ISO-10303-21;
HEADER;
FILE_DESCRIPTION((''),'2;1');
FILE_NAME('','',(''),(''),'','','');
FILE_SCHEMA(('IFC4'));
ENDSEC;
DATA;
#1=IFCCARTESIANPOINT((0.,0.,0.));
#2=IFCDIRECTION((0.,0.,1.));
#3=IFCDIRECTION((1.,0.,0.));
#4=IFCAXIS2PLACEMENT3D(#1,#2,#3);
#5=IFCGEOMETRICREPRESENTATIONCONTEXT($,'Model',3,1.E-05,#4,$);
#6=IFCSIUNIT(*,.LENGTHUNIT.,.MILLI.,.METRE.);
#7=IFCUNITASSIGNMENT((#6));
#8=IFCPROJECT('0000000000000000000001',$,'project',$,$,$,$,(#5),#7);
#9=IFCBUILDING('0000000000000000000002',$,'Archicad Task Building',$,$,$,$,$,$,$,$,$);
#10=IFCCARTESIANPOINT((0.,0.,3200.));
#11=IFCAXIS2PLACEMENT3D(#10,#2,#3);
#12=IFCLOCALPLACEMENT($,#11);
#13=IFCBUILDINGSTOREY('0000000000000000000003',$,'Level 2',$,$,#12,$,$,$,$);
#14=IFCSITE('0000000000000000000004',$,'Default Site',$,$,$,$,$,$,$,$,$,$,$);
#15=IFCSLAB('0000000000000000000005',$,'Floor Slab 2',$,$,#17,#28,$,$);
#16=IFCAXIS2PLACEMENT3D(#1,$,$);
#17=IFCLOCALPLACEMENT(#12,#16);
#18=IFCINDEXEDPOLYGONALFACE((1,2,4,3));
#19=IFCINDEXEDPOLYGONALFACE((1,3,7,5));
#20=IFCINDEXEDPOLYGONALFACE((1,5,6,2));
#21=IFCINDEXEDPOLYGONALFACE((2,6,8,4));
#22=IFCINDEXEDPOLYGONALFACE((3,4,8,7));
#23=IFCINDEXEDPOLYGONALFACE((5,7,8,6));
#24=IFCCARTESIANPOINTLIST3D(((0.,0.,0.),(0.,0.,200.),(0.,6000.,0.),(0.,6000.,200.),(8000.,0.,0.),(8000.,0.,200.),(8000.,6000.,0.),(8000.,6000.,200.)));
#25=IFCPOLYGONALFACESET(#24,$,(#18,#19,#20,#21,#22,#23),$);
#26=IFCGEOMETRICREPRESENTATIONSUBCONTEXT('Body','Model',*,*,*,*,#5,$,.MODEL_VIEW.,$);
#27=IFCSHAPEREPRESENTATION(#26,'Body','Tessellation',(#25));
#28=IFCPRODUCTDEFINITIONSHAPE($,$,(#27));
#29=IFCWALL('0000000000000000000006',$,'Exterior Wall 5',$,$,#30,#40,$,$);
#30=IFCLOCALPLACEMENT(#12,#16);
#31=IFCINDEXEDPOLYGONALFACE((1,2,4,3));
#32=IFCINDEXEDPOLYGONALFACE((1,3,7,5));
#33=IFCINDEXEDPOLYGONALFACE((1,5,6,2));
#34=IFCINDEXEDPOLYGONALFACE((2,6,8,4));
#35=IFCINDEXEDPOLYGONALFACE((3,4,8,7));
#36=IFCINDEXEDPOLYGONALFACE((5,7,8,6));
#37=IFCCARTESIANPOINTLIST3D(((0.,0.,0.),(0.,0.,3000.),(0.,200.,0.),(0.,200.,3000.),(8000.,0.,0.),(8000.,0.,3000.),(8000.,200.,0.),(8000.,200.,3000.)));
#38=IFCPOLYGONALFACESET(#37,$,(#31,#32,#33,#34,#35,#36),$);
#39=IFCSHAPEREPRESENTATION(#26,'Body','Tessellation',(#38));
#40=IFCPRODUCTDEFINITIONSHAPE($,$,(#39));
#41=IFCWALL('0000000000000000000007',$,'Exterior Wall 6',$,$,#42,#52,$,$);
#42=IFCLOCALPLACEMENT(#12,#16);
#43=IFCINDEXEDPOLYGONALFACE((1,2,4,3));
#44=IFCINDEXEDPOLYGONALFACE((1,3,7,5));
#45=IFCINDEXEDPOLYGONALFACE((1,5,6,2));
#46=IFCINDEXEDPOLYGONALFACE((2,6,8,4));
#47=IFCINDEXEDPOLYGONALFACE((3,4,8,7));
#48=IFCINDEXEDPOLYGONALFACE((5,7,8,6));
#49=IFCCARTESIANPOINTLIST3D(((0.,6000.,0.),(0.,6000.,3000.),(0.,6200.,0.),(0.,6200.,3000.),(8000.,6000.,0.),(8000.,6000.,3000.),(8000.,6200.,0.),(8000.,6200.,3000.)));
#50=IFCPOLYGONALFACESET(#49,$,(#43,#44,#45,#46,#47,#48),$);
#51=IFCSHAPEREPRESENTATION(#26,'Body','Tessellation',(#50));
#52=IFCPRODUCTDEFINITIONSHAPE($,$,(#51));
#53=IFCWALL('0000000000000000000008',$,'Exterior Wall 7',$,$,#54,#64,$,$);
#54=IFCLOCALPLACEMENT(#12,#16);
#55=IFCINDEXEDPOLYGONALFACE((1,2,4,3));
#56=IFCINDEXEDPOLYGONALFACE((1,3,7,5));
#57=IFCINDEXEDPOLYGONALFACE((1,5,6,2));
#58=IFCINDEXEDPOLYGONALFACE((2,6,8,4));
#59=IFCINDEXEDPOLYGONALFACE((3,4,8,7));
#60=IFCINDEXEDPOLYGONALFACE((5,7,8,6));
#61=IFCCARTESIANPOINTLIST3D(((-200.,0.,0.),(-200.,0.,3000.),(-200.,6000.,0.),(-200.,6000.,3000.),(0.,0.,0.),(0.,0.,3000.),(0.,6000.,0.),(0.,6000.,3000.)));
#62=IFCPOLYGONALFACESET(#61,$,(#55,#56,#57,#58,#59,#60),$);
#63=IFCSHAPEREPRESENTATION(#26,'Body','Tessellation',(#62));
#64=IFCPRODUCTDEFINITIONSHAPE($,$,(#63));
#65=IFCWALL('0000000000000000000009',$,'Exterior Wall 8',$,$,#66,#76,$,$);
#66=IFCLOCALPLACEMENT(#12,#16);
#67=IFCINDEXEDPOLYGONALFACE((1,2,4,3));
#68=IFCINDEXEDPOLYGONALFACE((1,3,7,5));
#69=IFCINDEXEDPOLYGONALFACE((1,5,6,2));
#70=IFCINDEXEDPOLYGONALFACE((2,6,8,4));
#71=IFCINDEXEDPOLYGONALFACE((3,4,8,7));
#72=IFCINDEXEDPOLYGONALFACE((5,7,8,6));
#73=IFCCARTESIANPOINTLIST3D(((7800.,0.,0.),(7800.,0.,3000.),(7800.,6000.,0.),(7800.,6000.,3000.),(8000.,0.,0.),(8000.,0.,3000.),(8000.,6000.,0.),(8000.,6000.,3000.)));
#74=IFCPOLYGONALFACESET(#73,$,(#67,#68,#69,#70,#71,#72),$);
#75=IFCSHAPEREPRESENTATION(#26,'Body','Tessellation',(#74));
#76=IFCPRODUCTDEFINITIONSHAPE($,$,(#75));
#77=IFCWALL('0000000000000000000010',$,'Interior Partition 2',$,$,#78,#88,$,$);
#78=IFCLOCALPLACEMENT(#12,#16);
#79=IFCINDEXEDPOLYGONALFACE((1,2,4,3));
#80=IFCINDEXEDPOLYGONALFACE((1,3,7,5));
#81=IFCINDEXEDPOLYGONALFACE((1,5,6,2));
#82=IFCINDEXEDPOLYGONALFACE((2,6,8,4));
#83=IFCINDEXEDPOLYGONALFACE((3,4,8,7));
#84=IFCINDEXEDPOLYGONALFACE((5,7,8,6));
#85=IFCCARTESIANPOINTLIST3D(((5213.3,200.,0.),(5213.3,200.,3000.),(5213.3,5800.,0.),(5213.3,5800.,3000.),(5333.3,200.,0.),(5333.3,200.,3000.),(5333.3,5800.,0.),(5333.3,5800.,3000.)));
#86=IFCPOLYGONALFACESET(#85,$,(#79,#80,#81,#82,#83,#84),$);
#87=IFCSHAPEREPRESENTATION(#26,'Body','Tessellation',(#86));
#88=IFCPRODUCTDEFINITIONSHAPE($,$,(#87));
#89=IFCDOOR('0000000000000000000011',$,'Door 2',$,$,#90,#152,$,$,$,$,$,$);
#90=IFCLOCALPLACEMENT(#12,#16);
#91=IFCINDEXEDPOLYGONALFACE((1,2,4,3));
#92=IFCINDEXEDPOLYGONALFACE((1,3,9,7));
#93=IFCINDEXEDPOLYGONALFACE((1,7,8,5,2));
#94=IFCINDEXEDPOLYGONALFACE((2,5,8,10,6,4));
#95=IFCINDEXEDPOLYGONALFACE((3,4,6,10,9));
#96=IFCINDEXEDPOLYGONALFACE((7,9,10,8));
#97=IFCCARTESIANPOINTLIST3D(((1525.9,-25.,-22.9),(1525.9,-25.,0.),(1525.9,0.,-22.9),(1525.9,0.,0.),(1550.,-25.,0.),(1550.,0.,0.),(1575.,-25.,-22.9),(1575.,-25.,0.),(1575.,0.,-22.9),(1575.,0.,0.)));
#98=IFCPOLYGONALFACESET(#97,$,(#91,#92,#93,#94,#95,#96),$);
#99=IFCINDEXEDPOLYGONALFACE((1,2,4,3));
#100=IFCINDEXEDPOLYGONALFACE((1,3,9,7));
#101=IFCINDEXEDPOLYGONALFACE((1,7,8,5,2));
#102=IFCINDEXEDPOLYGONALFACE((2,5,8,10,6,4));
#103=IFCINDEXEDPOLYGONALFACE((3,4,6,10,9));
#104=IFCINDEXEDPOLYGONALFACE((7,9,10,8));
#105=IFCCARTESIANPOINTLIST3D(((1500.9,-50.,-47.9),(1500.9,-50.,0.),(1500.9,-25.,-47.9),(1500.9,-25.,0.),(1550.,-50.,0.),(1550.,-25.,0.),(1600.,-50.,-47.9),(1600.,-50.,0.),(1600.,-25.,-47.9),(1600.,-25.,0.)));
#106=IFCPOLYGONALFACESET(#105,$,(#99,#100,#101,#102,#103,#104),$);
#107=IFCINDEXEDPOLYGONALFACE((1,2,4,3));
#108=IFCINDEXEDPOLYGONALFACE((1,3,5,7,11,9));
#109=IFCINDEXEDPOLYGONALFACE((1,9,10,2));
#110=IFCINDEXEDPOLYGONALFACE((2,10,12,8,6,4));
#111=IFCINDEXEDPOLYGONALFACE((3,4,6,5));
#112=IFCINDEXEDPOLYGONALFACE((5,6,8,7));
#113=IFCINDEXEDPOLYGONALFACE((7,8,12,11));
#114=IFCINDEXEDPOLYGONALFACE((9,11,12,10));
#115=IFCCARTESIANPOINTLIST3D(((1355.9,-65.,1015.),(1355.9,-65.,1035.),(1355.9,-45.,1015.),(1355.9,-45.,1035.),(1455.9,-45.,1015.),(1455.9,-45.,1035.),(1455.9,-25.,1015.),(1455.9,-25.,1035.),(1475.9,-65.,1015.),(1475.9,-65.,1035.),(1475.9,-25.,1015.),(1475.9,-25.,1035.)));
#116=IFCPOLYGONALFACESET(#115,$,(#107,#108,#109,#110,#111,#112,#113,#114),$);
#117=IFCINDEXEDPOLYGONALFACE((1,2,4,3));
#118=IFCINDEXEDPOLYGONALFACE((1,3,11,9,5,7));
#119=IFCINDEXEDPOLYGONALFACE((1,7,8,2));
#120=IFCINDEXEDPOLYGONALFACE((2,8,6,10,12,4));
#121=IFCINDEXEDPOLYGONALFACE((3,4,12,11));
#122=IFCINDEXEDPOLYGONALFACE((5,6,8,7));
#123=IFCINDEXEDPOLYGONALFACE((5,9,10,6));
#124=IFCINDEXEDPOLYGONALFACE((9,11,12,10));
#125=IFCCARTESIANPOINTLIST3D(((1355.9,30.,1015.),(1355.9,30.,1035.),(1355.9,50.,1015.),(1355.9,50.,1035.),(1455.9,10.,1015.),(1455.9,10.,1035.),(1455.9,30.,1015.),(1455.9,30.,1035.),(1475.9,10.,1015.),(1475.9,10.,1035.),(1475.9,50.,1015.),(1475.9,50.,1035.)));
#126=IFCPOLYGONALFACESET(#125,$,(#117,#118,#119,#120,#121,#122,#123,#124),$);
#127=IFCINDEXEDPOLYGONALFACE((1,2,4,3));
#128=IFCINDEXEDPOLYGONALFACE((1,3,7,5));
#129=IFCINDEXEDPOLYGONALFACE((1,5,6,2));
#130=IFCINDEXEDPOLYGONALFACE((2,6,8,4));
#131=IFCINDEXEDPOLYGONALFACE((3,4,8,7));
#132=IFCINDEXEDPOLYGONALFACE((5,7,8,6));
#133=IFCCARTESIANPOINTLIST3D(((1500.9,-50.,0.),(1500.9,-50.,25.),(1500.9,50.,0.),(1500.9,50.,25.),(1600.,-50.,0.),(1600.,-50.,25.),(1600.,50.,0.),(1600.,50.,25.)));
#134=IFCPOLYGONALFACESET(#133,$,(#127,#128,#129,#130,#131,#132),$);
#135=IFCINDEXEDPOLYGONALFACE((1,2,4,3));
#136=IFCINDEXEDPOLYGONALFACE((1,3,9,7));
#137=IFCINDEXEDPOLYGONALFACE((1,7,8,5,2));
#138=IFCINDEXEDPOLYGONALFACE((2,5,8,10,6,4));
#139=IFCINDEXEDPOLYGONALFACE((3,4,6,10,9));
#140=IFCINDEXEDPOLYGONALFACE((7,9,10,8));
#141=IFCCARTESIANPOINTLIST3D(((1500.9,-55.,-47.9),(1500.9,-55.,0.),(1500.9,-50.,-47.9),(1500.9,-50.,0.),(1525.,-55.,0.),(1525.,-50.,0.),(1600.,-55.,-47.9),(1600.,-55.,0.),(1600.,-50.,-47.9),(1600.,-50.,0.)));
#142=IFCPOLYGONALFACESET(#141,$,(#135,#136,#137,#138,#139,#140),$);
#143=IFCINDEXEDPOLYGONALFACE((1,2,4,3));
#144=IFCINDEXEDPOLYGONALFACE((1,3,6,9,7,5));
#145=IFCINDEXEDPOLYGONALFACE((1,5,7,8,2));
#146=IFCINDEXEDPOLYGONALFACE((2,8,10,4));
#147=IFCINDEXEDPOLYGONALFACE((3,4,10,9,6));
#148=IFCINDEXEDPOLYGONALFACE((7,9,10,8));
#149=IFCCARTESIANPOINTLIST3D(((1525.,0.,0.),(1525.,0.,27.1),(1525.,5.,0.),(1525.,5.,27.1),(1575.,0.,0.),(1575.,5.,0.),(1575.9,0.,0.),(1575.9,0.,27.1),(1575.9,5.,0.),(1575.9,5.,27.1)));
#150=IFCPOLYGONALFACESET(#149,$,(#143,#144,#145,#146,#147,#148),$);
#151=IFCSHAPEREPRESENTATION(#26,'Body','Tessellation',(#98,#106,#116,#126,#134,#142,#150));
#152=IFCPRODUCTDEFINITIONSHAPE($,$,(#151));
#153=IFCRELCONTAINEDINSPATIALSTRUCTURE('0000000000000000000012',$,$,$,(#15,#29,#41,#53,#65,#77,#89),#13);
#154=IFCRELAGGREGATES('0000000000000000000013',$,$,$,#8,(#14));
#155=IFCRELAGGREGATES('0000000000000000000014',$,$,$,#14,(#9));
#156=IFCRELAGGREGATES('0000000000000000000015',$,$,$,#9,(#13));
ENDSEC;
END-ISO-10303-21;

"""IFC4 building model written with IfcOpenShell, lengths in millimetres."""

from ifc_helpers import new_model, si_unit, frame, origin_with_axes, place, context, subcontext, project, spatial, line, indexed_curve, outline, extrude, element, save


model = new_model("IFC4")

# Units and contexts
model_context = context("Model", 3, precision=1e-05, world=origin_with_axes())
body_context = subcontext(model_context, "Body", "Model", "MODEL_VIEW")
ifc_project = project(units=[si_unit("LENGTHUNIT", "METRE", prefix="MILLI")], contexts=[model_context])

# Site, building, storey
site = spatial("IfcSite", under=ifc_project, Name="Default Site")
building = spatial("IfcBuilding", under=site, Name="Archicad Task Building")
storey_placement = place(None, frame((0.0, 0.0, 3200.0), z_axis=(0.0, 0.0, 1.0), x_axis=(1.0, 0.0, 0.0)))
storey = spatial("IfcBuildingStorey", under=building, at=storey_placement, Name="Level 2")

# Slab
slab_placement = place(storey_placement, origin_with_axes())
element("IfcSlab", 1, at=slab_placement, inside=storey, Name="Floor Slab 2", context=body_context, shape_type="SweptSolid", body=[
    extrude(outline(indexed_curve([(0.0, 0.0), (8000.0, 0.0), (8000.0, 6000.0), (0.0, 6000.0), (0.0, 0.0)])), None, (0.0, 0.0, 1.0), 200.0),
])

# Walls
for number, where, z_axis, x_axis, name in (
    (2, (0.0, 0.0, 0.0), (0.0, 0.0, 1.0), (1.0, 0.0, 0.0), "Exterior Wall 5"),
    (3, (0.0, 6000.0, 0.0), (0.0, 0.0, 1.0), (1.0, 0.0, 0.0), "Exterior Wall 6"),
):
    element("IfcWall", number, at=place(storey_placement, frame(where, z_axis=z_axis, x_axis=x_axis)), inside=storey, Name=name, context=body_context, shape_type="SweptSolid", body=[
        extrude(outline(indexed_curve([(0.0, 0.0), (0.0, 200.0), (8000.0, 200.0), (8000.0, 0.0), (0.0, 0.0)], self_intersect=False)), origin_with_axes(), (0.0, 0.0, 1.0), 3000.0),
    ])
for number, where, z_axis, x_axis, name in (
    (4, (0.0, 0.0, 0.0), (0.0, 0.0, 1.0), (0.0, 1.0, 0.0), "Exterior Wall 7"),
    (5, (8000.0, 0.0, 0.0), (0.0, 0.0, 1.0), (0.0, 1.0, 0.0), "Exterior Wall 8"),
):
    element("IfcWall", number, at=place(storey_placement, frame(where, z_axis=z_axis, x_axis=x_axis)), inside=storey, Name=name, context=body_context, shape_type="SweptSolid", body=[
        extrude(outline(indexed_curve([(0.0, 0.0), (0.0, 200.0), (6000.0, 200.0), (6000.0, 0.0), (0.0, 0.0)], self_intersect=False)), origin_with_axes(), (0.0, 0.0, 1.0), 3000.0),
    ])
wall_placement = place(storey_placement, frame((5333.3, 200.0, 0.0), z_axis=(0.0, 0.0, 1.0), x_axis=(0.0, 1.0, 0.0)))
element("IfcWall", 6, at=wall_placement, inside=storey, Name="Interior Partition 2", context=body_context, shape_type="SweptSolid", body=[
    extrude(outline(indexed_curve([(0.0, 0.0), (0.0, 120.0), (5600.0, 120.0), (5600.0, 0.0), (0.0, 0.0)], self_intersect=False)), origin_with_axes(), (0.0, 0.0, 1.0), 3000.0),
])

# Door
door_1_placement = place(storey_placement, frame((1550.0, -50.0, 0.0), z_axis=(0.0, 0.0, 1.0), x_axis=(1.0, 0.0, 0.0)))
element("IfcDoor", 7, at=door_1_placement, inside=storey, Name="Door 2", context=body_context, shape_type="SweptSolid", body=[
    extrude(outline(indexed_curve([(0.0, 0.0), (0.0, 2.1), (0.9, 2.1), (0.9, 0.0), (-24.1, 0.0), (-24.1, -22.9), (25.0, -22.9), (25.0, 0.0)], segments=[line(1, 2, 3, 4, 5, 6, 7, 8, 1)])), frame((0.0, 25.0, 0.0), z_axis=(0.0, -1.0, 0.0), x_axis=(1.0, 0.0, 0.0)), (0.0, 0.0, -1.0), 25.0),
    extrude(outline(indexed_curve([(0.0, 0.0), (0.0, 2.1), (0.9, 2.1), (0.9, 0.0), (-49.1, 0.0), (-49.1, -47.9), (50.0, -47.9), (50.0, 0.0)], segments=[line(1, 2, 3, 4, 5, 6, 7, 8, 1)])), frame((0.0, 0.0, 0.0), z_axis=(0.0, -1.0, 0.0), x_axis=(1.0, 0.0, 0.0)), (0.0, 0.0, -1.0), 25.0),
    extrude(outline(indexed_curve([(0.0, 0.0), (-49.1, 0.0), (-49.1, 35.0), (0.0, 35.0)], segments=[line(1, 2, 3, 4, 1)])), frame((25.0, 25.0, 25.0), z_axis=(0.0, 0.0, 1.0), x_axis=(1.0, 0.0, 0.0)), (0.0, 0.0, 1.0), -47.9),
    extrude(outline(indexed_curve([(0.0, 0.0), (0.0, -40.0), (-120.0, -40.0), (-120.0, -20.0), (-20.0, -20.0), (-20.0, 0.0)], segments=[line(1, 2, 3, 4, 5, 6, 1)])), frame((-74.1, 25.0, 1015.0), z_axis=(0.0, 0.0, 1.0), x_axis=(1.0, 0.0, 0.0)), (0.0, 0.0, 1.0), 20.0),
    extrude(outline(indexed_curve([(0.0, 0.0), (0.0, 40.0), (-120.0, 40.0), (-120.0, 20.0), (-20.0, 20.0), (-20.0, 0.0)], segments=[line(1, 2, 3, 4, 5, 6, 1)])), frame((-74.1, 60.0, 1015.0), z_axis=(0.0, 0.0, 1.0), x_axis=(1.0, 0.0, 0.0)), (0.0, 0.0, 1.0), 20.0),
    extrude(outline(indexed_curve([(0.0, 0.0), (-99.1, 0.0), (-99.1, 100.0), (0.0, 100.0)], segments=[line(1, 2, 3, 4, 1)])), frame((50.0, 0.0, 0.0), z_axis=(0.0, 0.0, 1.0), x_axis=(1.0, 0.0, 0.0)), (0.0, 0.0, 1.0), 25.0),
    extrude(outline(indexed_curve([(0.0, 0.0), (0.0, 27.1), (50.9, 27.1), (50.9, 0.0), (-24.1, 0.0), (-24.1, -47.9), (75.0, -47.9), (75.0, 0.0)], segments=[line(1, 2, 3, 4, 5, 6, 7, 8, 1)])), frame((-25.0, -5.0, 0.0), z_axis=(0.0, -1.0, 0.0), x_axis=(1.0, 0.0, 0.0)), (0.0, 0.0, -1.0), 5.0),
    extrude(outline(indexed_curve([(0.0, 0.0), (0.0, 27.1), (50.9, 27.1), (50.9, 0.0), (0.9, 0.0), (0.9, -22.9), (50.0, -22.9), (50.0, 0.0)], segments=[line(1, 2, 3, 4, 5, 6, 7, 8, 1)])), frame((-25.0, 50.0, 0.0), z_axis=(0.0, -1.0, 0.0), x_axis=(1.0, 0.0, 0.0)), (0.0, 0.0, -1.0), 5.0),
])

save(model, "model.ifc")
